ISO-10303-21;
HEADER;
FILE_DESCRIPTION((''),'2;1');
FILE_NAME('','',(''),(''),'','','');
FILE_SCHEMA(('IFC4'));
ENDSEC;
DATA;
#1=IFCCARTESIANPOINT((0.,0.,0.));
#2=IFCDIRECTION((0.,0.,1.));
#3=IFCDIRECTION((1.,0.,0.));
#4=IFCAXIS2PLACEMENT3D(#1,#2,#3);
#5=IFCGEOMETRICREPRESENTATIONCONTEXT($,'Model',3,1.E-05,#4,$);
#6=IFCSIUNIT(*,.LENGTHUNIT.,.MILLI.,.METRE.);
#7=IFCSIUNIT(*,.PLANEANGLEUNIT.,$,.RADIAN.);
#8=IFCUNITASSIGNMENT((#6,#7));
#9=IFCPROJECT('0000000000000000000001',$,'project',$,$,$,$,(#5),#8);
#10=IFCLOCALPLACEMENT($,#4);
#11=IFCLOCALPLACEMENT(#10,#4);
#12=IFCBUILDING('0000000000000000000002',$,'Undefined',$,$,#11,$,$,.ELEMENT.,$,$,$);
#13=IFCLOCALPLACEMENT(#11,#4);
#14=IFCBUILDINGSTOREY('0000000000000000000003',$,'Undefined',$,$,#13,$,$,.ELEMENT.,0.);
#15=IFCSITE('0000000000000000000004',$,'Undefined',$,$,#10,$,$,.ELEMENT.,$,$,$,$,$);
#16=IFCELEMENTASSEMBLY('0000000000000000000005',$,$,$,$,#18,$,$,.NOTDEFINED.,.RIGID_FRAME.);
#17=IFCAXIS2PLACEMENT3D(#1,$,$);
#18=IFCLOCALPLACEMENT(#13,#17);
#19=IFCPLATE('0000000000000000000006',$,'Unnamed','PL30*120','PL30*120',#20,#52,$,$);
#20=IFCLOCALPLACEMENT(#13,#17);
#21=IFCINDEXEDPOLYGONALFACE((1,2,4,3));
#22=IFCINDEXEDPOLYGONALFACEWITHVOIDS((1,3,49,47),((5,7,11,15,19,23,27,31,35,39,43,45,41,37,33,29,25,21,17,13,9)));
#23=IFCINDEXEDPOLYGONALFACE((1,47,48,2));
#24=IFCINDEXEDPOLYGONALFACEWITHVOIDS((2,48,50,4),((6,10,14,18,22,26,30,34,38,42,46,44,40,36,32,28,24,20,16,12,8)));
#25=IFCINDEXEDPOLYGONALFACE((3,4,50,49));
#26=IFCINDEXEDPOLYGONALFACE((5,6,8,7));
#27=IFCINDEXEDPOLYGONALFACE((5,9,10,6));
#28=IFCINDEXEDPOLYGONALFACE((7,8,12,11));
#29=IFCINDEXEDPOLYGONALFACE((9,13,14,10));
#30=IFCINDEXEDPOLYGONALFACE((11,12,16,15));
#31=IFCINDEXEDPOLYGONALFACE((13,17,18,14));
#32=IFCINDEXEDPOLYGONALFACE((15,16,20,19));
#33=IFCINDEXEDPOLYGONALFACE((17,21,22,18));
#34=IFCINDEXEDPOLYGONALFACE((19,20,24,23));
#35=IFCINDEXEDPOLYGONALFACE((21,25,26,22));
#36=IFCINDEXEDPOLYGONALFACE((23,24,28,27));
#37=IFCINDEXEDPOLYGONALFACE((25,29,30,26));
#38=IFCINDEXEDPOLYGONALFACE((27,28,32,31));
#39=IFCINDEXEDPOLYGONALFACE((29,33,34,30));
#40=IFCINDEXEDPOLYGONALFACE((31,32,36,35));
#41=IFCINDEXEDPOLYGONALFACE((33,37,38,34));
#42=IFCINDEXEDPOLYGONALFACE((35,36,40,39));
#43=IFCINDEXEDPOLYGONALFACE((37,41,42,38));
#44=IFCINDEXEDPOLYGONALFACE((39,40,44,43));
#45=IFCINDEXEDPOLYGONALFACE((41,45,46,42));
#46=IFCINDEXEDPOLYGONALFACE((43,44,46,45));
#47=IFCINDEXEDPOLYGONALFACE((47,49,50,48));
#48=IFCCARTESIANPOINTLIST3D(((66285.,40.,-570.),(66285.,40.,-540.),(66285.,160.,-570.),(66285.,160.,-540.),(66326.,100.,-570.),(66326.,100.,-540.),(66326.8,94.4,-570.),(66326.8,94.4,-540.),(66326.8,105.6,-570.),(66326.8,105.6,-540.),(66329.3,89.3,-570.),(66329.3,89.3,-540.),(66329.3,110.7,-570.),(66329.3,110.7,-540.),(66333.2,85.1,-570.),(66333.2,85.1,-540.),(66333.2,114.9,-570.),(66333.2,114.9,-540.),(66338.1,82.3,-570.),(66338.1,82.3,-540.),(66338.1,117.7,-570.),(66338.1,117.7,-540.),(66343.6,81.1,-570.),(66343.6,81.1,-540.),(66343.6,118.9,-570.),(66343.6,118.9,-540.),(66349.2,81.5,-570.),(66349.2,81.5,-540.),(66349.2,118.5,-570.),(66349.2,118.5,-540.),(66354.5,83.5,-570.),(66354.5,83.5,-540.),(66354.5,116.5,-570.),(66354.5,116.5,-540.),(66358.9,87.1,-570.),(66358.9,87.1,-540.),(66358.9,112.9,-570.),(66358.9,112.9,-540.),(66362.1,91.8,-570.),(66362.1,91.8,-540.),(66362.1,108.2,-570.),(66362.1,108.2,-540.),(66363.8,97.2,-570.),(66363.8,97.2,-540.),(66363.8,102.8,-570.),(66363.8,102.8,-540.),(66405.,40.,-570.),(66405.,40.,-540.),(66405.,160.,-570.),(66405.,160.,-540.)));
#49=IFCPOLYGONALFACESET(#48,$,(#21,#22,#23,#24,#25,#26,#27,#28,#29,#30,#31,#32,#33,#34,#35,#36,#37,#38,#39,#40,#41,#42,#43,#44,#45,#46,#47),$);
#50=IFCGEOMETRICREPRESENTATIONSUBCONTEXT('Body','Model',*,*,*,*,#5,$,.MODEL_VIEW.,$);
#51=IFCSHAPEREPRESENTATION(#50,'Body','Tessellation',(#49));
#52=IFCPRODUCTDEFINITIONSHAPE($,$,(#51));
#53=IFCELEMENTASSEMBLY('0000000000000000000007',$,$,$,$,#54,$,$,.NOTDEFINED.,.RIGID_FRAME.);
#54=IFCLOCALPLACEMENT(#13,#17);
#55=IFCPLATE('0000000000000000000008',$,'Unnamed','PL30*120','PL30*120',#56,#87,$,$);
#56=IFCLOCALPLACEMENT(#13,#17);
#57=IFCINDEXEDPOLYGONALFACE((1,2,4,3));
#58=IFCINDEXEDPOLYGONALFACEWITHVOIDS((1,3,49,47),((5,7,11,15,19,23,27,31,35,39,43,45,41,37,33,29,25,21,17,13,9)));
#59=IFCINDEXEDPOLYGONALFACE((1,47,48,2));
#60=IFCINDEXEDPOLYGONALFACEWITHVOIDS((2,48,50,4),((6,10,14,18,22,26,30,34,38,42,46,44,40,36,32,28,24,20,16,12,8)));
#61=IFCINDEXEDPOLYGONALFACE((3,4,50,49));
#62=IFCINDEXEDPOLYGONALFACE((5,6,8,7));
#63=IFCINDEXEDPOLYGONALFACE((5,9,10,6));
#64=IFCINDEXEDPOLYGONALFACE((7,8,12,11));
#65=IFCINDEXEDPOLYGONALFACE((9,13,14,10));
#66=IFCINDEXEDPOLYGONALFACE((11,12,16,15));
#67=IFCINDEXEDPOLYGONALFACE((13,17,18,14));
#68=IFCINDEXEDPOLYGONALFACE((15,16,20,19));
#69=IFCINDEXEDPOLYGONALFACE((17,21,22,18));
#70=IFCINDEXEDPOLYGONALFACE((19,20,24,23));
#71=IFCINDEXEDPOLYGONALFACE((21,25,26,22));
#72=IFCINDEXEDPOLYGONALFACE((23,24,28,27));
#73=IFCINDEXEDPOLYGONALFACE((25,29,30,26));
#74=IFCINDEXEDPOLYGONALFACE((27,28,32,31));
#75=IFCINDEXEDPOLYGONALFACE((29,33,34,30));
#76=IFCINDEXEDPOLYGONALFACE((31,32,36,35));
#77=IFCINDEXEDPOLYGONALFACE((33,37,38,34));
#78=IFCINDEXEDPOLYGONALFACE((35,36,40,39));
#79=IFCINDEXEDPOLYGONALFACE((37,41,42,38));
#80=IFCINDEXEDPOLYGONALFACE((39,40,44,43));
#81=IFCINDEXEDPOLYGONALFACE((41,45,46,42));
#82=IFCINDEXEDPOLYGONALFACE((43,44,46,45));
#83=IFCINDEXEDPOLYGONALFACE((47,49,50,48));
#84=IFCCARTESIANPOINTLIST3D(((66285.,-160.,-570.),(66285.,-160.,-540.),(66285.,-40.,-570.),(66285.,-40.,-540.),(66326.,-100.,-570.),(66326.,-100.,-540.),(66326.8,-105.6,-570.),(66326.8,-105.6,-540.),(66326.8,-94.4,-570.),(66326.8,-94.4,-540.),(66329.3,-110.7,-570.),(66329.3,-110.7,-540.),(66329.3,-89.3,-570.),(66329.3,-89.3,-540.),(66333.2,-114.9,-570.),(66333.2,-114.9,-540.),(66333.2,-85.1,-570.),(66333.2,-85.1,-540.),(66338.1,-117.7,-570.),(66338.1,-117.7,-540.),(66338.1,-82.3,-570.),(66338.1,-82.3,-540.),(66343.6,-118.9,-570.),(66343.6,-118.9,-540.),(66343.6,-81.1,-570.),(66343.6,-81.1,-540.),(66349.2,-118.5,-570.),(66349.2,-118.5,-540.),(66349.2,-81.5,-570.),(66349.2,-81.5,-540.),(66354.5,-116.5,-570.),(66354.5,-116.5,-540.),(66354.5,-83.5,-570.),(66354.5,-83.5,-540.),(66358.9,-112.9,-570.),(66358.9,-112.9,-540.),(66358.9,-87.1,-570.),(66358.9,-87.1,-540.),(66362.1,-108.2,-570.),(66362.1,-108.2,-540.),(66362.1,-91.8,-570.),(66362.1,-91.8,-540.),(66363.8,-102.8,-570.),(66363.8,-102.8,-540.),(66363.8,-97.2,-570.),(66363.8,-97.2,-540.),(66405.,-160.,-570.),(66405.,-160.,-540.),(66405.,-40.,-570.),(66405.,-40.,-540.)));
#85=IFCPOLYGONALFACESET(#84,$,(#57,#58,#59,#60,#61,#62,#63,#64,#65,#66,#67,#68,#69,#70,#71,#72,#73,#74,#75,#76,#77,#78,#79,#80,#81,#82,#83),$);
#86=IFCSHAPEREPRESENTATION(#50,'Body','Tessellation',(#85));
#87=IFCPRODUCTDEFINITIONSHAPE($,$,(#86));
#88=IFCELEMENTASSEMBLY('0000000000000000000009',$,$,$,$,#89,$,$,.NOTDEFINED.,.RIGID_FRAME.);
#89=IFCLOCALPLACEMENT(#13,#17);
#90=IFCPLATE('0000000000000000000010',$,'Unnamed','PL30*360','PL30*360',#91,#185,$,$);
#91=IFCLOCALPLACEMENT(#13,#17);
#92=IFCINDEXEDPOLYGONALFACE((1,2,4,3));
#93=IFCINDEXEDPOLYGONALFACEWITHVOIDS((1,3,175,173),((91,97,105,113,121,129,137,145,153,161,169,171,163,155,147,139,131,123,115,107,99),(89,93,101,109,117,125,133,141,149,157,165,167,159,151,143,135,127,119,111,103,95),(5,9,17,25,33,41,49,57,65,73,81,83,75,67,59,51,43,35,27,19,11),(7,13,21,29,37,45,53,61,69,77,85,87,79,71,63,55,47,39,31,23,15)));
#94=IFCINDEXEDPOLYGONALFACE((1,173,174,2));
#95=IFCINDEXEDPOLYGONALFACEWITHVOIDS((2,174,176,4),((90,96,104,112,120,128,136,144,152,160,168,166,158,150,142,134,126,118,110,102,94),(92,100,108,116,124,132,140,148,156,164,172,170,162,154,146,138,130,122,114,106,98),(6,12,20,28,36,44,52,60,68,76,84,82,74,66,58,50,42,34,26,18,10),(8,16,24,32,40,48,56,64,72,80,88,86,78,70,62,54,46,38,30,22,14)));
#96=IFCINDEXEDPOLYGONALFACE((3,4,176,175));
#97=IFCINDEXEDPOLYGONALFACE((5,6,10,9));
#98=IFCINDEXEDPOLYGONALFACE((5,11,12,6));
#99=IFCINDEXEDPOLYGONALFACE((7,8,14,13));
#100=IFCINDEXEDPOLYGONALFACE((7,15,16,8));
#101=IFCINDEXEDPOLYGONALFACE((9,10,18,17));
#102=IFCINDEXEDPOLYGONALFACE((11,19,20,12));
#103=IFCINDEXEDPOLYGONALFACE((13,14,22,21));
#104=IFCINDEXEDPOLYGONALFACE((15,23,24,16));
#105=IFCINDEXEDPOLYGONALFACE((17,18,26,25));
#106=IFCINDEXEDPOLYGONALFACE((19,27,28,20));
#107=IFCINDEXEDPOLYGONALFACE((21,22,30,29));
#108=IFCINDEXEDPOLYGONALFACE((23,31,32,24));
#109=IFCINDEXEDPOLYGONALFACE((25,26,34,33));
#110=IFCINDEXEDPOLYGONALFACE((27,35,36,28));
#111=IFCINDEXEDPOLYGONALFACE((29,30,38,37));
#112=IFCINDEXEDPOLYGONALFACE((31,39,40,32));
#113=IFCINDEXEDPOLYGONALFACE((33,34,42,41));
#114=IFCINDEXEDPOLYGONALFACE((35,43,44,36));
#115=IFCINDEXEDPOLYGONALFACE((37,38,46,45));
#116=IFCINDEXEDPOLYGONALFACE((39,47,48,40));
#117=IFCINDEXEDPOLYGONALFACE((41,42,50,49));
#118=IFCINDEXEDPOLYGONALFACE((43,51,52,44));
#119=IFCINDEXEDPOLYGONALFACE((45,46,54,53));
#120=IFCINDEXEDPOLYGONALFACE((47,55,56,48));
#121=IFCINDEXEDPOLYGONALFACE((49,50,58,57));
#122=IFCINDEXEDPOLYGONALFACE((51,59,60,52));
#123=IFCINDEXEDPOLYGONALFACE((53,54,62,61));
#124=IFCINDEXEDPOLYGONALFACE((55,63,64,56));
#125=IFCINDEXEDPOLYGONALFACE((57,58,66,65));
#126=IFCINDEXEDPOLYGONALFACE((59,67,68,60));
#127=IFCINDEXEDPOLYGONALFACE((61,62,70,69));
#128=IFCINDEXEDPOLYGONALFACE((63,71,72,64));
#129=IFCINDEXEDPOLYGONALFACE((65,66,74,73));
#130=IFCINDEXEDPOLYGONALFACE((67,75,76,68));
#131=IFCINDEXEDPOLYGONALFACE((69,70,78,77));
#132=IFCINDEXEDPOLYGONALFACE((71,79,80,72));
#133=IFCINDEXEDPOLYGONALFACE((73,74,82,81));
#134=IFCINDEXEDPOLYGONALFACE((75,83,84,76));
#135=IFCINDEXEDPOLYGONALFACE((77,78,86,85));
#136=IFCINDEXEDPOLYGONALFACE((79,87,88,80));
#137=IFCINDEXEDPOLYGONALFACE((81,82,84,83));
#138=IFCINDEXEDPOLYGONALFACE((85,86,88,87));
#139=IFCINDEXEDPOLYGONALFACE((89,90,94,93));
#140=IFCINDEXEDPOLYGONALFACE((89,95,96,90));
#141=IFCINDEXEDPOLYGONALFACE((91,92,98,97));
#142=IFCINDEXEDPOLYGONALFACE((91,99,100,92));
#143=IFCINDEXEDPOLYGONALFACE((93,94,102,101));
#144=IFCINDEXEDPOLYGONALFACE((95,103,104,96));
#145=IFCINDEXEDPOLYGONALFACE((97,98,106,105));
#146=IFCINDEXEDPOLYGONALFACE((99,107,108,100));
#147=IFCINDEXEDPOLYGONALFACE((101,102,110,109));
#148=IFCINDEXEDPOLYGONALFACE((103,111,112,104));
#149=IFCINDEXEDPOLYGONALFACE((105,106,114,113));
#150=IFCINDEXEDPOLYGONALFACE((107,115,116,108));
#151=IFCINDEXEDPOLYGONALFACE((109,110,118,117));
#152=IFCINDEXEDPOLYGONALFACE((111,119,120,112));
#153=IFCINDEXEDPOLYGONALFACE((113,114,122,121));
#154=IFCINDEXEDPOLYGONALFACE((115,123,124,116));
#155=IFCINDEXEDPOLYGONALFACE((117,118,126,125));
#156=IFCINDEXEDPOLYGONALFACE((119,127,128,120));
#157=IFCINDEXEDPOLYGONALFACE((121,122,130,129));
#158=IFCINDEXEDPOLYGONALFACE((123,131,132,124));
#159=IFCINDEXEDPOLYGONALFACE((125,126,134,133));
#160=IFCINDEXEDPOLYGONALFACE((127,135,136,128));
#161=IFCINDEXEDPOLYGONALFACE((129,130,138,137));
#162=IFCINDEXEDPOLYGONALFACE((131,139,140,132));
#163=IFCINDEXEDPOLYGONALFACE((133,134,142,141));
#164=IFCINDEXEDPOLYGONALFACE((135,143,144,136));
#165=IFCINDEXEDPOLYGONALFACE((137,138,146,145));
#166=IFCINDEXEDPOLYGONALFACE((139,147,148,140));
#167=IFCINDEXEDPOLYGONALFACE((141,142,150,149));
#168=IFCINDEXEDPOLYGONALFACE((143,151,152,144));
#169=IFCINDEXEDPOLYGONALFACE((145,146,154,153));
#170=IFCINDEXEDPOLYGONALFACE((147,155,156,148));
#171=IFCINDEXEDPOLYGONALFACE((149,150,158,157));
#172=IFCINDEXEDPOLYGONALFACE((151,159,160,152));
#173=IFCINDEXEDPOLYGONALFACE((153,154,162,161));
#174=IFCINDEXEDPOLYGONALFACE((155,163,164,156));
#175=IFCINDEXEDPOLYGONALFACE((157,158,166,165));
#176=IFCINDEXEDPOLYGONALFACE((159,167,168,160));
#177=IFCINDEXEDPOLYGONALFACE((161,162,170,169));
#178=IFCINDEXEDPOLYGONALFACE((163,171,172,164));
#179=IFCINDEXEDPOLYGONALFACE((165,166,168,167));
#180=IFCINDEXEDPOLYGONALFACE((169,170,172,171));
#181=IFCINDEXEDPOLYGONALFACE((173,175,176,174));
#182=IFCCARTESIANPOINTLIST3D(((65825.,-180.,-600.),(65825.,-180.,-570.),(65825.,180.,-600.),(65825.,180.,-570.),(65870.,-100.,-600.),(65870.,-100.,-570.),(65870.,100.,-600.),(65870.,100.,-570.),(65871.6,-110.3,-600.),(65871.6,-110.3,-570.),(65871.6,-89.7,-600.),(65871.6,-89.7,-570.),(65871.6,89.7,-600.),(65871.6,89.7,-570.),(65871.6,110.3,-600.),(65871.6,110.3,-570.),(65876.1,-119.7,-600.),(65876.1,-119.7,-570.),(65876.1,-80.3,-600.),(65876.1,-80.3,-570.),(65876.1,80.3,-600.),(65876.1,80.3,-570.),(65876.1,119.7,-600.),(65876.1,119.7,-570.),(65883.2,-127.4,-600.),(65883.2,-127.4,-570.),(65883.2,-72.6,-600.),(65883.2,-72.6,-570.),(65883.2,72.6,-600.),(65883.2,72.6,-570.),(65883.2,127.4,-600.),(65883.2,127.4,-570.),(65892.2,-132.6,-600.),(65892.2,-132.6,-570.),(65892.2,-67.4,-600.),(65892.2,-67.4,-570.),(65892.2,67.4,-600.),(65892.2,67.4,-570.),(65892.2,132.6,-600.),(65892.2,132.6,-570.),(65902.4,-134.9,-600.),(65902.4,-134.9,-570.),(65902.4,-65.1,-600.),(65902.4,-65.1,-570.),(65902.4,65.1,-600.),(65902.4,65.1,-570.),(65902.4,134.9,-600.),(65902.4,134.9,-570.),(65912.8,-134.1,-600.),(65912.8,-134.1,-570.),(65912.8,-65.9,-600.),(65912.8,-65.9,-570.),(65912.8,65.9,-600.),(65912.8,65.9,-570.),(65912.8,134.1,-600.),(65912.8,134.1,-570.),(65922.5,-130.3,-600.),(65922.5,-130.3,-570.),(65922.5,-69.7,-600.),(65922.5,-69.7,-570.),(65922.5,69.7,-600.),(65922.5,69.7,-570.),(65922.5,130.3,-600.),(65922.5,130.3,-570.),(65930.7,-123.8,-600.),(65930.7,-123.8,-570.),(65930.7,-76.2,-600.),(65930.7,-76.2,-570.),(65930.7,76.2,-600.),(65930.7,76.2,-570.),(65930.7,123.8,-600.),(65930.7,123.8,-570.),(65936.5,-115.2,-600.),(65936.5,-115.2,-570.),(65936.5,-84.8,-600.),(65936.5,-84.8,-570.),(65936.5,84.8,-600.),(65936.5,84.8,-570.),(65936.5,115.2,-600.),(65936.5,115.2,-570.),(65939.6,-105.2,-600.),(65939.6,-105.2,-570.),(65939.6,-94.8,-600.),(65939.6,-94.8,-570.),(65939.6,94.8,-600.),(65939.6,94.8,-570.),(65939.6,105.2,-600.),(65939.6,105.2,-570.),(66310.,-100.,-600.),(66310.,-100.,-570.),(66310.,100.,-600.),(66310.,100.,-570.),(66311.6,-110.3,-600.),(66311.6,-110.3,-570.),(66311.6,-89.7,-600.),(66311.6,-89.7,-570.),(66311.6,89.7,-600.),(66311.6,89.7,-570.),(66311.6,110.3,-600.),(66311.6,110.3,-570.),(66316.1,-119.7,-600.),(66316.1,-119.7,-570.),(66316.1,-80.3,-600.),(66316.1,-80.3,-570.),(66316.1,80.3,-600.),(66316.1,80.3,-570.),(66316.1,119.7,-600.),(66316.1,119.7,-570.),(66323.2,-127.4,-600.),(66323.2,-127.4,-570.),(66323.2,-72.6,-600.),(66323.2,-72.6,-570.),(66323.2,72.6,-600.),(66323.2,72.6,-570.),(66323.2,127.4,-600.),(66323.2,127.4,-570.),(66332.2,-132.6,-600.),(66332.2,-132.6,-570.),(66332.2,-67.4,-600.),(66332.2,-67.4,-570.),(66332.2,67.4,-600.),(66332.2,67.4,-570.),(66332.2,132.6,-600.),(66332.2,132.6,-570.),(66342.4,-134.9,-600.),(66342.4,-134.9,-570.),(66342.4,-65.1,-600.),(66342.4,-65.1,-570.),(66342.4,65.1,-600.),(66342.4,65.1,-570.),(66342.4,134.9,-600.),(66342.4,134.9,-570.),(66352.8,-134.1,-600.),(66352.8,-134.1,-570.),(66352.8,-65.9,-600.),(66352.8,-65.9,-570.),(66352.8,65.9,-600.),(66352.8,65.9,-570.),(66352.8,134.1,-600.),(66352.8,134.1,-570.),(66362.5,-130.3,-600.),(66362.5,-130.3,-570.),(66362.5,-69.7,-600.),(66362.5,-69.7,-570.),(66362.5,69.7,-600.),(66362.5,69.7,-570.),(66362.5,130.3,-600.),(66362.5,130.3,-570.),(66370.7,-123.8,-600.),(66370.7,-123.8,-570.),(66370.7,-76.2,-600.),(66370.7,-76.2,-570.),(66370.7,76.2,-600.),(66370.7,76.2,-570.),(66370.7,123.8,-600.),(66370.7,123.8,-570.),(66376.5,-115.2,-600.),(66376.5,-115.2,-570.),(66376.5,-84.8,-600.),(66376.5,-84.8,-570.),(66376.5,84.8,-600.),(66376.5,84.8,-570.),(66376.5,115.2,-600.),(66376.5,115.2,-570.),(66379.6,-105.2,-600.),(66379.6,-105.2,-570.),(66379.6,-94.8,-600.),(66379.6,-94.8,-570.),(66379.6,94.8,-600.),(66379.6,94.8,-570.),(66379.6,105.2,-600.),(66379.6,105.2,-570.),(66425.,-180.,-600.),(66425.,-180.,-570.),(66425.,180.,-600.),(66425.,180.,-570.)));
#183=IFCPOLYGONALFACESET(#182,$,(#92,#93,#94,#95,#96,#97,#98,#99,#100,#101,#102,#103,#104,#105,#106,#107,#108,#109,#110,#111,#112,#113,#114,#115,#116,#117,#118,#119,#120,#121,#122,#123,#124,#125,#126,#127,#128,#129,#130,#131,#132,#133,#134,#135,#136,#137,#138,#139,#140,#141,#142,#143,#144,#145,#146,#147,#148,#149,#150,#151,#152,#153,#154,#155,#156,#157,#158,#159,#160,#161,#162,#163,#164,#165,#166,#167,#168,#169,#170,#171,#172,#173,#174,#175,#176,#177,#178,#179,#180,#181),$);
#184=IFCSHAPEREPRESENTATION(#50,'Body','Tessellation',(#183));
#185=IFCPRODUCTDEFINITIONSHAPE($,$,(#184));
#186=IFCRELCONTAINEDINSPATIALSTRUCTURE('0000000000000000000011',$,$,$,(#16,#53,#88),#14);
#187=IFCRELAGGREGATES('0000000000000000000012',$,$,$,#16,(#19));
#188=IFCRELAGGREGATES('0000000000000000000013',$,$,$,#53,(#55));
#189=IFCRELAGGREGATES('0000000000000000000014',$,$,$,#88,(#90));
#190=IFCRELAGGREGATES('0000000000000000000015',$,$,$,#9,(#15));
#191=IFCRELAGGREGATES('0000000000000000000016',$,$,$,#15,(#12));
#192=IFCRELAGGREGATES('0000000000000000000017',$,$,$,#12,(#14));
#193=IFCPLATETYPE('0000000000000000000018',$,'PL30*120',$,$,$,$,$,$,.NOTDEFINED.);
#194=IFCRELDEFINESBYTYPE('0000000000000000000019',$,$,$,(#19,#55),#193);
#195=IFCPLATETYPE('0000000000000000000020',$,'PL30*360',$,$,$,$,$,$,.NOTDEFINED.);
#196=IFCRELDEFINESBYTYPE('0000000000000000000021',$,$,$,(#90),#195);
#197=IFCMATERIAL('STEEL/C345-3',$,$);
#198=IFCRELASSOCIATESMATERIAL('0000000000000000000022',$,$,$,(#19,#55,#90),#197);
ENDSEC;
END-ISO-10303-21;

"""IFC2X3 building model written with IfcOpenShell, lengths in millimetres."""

from ifc_helpers import new_model, si_unit, frame, origin_with_axes, origin_2d_with_axis, place, context, subcontext, project, spatial, polyline, circle, outline, extrude, boolean, material, type_object, element, aggregate, save


model = new_model("IFC2X3")

# Units and contexts
model_context = context("Model", 3, precision=1e-05, world=origin_with_axes())
body_context = subcontext(model_context, "Body", "Model", "MODEL_VIEW")
ifc_project = project(units=[si_unit("LENGTHUNIT", "METRE", prefix="MILLI"), si_unit("PLANEANGLEUNIT", "RADIAN")], contexts=[model_context])

# Site, building, storey
site_placement = place(None, origin_with_axes())
site = spatial("IfcSite", under=ifc_project, at=site_placement, Name="Undefined", CompositionType="ELEMENT")
building_placement = place(site_placement, origin_with_axes())
building = spatial("IfcBuilding", under=site, at=building_placement, Name="Undefined", CompositionType="ELEMENT")
storey_placement = place(building_placement, origin_with_axes())
storey = spatial("IfcBuildingStorey", under=building, at=storey_placement, Name="Undefined", CompositionType="ELEMENT", Elevation=0.0)

# Shared definitions
ifc_material_1 = material(Name="STEEL/C345-3")

# Element assemblies, plates
plate_type_1 = type_object("IfcPlateType", Name="PL30*120", PredefinedType="NOTDEFINED")
assembly_1_placement = place(storey_placement, origin_with_axes())
assembly_1 = element("IfcElementAssembly", 1, at=assembly_1_placement, inside=storey, AssemblyPlace="NOTDEFINED", PredefinedType="RIGID_FRAME")
plate_1_placement = place(assembly_1_placement, frame((66285.0, 40.0, -555.0), z_axis=(0.0, 0.0, -1.0), x_axis=(0.0, 1.0, 0.0)))
plate_1 = element("IfcPlate", 2, at=plate_1_placement, type_object=plate_type_1, material=ifc_material_1, Name="Unnamed", Description="PL30*120", ObjectType="PL30*120", context=body_context, shape_type="CSG", body=[
    boolean("DIFFERENCE", extrude(outline(polyline([(0.0, 0.0), (120.0, 0.0), (120.0, 120.0), (0.0, 120.0), (0.0, 0.0)])), frame((0.0, 0.0, -15.0), z_axis=(0.0, 0.0, 1.0), x_axis=(1.0, 0.0, 0.0)), (0.0, 0.0, 1.0), 30.0), extrude(circle(Radius=19.0, at=origin_2d_with_axis()), frame((60.0, 60.0, -45.0), z_axis=(0.0, 0.0, 1.0), x_axis=(0.0, -1.0, 0.0)), (0.0, 0.0, 1.0), 80.0)),
])
aggregate(assembly_1, [plate_1])
assembly_2_placement = place(storey_placement, origin_with_axes())
assembly_2 = element("IfcElementAssembly", 3, at=assembly_2_placement, inside=storey, AssemblyPlace="NOTDEFINED", PredefinedType="RIGID_FRAME")
plate_2_placement = place(assembly_2_placement, frame((66285.0, -160.0, -555.0), z_axis=(0.0, 0.0, -1.0), x_axis=(0.0, 1.0, 0.0)))
plate_2 = element("IfcPlate", 4, at=plate_2_placement, type_object=plate_type_1, material=ifc_material_1, Name="Unnamed", Description="PL30*120", ObjectType="PL30*120", context=body_context, shape_type="CSG", body=[
    boolean("DIFFERENCE", extrude(outline(polyline([(0.0, 0.0), (120.0, 0.0), (120.0, 120.0), (0.0, 120.0), (0.0, 0.0)])), frame((0.0, 0.0, -15.0), z_axis=(0.0, 0.0, 1.0), x_axis=(1.0, 0.0, 0.0)), (0.0, 0.0, 1.0), 30.0), extrude(circle(Radius=19.0, at=origin_2d_with_axis()), frame((60.0, 60.0, -45.0), z_axis=(0.0, 0.0, 1.0), x_axis=(0.0, -1.0, 0.0)), (0.0, 0.0, 1.0), 80.0)),
])
aggregate(assembly_2, [plate_2])
assembly_3_placement = place(storey_placement, origin_with_axes())
assembly_3 = element("IfcElementAssembly", 5, at=assembly_3_placement, inside=storey, AssemblyPlace="NOTDEFINED", PredefinedType="RIGID_FRAME")
plate_type_2 = type_object("IfcPlateType", Name="PL30*360", PredefinedType="NOTDEFINED")
plate_3_placement = place(assembly_3_placement, frame((66425.0, 180.0, -585.0), z_axis=(0.0, 0.0, -1.0), x_axis=(0.0, -1.0, 0.0)))
plate_3 = element("IfcPlate", 6, at=plate_3_placement, type_object=plate_type_2, material=ifc_material_1, Name="Unnamed", Description="PL30*360", ObjectType="PL30*360", context=body_context, shape_type="CSG", body=[
    boolean("DIFFERENCE", boolean("DIFFERENCE", boolean("DIFFERENCE", boolean("DIFFERENCE", extrude(outline(polyline([(0.0, 0.0), (360.0, 0.0), (360.0, 600.0), (0.0, 600.0), (0.0, 0.0)])), frame((0.0, 0.0, -15.0), z_axis=(0.0, 0.0, 1.0), x_axis=(1.0, 0.0, 0.0)), (0.0, 0.0, 1.0), 30.0), extrude(circle(Radius=35.0, at=origin_2d_with_axis()), frame((80.0, 520.0, -25.0), z_axis=(0.0, 0.0, 1.0), x_axis=(0.0, 1.0, 0.0)), (0.0, 0.0, 1.0), 60.0)), extrude(circle(Radius=35.0, at=origin_2d_with_axis()), frame((280.0, 520.0, -25.0), z_axis=(0.0, 0.0, 1.0), x_axis=(0.0, 1.0, 0.0)), (0.0, 0.0, 1.0), 60.0)), extrude(circle(Radius=35.0, at=origin_2d_with_axis()), frame((80.0, 80.0, -25.0), z_axis=(0.0, 0.0, 1.0), x_axis=(0.0, 1.0, 0.0)), (0.0, 0.0, 1.0), 60.0)), extrude(circle(Radius=35.0, at=origin_2d_with_axis()), frame((280.0, 80.0, -25.0), z_axis=(0.0, 0.0, 1.0), x_axis=(0.0, 1.0, 0.0)), (0.0, 0.0, 1.0), 60.0)),
])
aggregate(assembly_3, [plate_3])

save(model, "model.ifc")
